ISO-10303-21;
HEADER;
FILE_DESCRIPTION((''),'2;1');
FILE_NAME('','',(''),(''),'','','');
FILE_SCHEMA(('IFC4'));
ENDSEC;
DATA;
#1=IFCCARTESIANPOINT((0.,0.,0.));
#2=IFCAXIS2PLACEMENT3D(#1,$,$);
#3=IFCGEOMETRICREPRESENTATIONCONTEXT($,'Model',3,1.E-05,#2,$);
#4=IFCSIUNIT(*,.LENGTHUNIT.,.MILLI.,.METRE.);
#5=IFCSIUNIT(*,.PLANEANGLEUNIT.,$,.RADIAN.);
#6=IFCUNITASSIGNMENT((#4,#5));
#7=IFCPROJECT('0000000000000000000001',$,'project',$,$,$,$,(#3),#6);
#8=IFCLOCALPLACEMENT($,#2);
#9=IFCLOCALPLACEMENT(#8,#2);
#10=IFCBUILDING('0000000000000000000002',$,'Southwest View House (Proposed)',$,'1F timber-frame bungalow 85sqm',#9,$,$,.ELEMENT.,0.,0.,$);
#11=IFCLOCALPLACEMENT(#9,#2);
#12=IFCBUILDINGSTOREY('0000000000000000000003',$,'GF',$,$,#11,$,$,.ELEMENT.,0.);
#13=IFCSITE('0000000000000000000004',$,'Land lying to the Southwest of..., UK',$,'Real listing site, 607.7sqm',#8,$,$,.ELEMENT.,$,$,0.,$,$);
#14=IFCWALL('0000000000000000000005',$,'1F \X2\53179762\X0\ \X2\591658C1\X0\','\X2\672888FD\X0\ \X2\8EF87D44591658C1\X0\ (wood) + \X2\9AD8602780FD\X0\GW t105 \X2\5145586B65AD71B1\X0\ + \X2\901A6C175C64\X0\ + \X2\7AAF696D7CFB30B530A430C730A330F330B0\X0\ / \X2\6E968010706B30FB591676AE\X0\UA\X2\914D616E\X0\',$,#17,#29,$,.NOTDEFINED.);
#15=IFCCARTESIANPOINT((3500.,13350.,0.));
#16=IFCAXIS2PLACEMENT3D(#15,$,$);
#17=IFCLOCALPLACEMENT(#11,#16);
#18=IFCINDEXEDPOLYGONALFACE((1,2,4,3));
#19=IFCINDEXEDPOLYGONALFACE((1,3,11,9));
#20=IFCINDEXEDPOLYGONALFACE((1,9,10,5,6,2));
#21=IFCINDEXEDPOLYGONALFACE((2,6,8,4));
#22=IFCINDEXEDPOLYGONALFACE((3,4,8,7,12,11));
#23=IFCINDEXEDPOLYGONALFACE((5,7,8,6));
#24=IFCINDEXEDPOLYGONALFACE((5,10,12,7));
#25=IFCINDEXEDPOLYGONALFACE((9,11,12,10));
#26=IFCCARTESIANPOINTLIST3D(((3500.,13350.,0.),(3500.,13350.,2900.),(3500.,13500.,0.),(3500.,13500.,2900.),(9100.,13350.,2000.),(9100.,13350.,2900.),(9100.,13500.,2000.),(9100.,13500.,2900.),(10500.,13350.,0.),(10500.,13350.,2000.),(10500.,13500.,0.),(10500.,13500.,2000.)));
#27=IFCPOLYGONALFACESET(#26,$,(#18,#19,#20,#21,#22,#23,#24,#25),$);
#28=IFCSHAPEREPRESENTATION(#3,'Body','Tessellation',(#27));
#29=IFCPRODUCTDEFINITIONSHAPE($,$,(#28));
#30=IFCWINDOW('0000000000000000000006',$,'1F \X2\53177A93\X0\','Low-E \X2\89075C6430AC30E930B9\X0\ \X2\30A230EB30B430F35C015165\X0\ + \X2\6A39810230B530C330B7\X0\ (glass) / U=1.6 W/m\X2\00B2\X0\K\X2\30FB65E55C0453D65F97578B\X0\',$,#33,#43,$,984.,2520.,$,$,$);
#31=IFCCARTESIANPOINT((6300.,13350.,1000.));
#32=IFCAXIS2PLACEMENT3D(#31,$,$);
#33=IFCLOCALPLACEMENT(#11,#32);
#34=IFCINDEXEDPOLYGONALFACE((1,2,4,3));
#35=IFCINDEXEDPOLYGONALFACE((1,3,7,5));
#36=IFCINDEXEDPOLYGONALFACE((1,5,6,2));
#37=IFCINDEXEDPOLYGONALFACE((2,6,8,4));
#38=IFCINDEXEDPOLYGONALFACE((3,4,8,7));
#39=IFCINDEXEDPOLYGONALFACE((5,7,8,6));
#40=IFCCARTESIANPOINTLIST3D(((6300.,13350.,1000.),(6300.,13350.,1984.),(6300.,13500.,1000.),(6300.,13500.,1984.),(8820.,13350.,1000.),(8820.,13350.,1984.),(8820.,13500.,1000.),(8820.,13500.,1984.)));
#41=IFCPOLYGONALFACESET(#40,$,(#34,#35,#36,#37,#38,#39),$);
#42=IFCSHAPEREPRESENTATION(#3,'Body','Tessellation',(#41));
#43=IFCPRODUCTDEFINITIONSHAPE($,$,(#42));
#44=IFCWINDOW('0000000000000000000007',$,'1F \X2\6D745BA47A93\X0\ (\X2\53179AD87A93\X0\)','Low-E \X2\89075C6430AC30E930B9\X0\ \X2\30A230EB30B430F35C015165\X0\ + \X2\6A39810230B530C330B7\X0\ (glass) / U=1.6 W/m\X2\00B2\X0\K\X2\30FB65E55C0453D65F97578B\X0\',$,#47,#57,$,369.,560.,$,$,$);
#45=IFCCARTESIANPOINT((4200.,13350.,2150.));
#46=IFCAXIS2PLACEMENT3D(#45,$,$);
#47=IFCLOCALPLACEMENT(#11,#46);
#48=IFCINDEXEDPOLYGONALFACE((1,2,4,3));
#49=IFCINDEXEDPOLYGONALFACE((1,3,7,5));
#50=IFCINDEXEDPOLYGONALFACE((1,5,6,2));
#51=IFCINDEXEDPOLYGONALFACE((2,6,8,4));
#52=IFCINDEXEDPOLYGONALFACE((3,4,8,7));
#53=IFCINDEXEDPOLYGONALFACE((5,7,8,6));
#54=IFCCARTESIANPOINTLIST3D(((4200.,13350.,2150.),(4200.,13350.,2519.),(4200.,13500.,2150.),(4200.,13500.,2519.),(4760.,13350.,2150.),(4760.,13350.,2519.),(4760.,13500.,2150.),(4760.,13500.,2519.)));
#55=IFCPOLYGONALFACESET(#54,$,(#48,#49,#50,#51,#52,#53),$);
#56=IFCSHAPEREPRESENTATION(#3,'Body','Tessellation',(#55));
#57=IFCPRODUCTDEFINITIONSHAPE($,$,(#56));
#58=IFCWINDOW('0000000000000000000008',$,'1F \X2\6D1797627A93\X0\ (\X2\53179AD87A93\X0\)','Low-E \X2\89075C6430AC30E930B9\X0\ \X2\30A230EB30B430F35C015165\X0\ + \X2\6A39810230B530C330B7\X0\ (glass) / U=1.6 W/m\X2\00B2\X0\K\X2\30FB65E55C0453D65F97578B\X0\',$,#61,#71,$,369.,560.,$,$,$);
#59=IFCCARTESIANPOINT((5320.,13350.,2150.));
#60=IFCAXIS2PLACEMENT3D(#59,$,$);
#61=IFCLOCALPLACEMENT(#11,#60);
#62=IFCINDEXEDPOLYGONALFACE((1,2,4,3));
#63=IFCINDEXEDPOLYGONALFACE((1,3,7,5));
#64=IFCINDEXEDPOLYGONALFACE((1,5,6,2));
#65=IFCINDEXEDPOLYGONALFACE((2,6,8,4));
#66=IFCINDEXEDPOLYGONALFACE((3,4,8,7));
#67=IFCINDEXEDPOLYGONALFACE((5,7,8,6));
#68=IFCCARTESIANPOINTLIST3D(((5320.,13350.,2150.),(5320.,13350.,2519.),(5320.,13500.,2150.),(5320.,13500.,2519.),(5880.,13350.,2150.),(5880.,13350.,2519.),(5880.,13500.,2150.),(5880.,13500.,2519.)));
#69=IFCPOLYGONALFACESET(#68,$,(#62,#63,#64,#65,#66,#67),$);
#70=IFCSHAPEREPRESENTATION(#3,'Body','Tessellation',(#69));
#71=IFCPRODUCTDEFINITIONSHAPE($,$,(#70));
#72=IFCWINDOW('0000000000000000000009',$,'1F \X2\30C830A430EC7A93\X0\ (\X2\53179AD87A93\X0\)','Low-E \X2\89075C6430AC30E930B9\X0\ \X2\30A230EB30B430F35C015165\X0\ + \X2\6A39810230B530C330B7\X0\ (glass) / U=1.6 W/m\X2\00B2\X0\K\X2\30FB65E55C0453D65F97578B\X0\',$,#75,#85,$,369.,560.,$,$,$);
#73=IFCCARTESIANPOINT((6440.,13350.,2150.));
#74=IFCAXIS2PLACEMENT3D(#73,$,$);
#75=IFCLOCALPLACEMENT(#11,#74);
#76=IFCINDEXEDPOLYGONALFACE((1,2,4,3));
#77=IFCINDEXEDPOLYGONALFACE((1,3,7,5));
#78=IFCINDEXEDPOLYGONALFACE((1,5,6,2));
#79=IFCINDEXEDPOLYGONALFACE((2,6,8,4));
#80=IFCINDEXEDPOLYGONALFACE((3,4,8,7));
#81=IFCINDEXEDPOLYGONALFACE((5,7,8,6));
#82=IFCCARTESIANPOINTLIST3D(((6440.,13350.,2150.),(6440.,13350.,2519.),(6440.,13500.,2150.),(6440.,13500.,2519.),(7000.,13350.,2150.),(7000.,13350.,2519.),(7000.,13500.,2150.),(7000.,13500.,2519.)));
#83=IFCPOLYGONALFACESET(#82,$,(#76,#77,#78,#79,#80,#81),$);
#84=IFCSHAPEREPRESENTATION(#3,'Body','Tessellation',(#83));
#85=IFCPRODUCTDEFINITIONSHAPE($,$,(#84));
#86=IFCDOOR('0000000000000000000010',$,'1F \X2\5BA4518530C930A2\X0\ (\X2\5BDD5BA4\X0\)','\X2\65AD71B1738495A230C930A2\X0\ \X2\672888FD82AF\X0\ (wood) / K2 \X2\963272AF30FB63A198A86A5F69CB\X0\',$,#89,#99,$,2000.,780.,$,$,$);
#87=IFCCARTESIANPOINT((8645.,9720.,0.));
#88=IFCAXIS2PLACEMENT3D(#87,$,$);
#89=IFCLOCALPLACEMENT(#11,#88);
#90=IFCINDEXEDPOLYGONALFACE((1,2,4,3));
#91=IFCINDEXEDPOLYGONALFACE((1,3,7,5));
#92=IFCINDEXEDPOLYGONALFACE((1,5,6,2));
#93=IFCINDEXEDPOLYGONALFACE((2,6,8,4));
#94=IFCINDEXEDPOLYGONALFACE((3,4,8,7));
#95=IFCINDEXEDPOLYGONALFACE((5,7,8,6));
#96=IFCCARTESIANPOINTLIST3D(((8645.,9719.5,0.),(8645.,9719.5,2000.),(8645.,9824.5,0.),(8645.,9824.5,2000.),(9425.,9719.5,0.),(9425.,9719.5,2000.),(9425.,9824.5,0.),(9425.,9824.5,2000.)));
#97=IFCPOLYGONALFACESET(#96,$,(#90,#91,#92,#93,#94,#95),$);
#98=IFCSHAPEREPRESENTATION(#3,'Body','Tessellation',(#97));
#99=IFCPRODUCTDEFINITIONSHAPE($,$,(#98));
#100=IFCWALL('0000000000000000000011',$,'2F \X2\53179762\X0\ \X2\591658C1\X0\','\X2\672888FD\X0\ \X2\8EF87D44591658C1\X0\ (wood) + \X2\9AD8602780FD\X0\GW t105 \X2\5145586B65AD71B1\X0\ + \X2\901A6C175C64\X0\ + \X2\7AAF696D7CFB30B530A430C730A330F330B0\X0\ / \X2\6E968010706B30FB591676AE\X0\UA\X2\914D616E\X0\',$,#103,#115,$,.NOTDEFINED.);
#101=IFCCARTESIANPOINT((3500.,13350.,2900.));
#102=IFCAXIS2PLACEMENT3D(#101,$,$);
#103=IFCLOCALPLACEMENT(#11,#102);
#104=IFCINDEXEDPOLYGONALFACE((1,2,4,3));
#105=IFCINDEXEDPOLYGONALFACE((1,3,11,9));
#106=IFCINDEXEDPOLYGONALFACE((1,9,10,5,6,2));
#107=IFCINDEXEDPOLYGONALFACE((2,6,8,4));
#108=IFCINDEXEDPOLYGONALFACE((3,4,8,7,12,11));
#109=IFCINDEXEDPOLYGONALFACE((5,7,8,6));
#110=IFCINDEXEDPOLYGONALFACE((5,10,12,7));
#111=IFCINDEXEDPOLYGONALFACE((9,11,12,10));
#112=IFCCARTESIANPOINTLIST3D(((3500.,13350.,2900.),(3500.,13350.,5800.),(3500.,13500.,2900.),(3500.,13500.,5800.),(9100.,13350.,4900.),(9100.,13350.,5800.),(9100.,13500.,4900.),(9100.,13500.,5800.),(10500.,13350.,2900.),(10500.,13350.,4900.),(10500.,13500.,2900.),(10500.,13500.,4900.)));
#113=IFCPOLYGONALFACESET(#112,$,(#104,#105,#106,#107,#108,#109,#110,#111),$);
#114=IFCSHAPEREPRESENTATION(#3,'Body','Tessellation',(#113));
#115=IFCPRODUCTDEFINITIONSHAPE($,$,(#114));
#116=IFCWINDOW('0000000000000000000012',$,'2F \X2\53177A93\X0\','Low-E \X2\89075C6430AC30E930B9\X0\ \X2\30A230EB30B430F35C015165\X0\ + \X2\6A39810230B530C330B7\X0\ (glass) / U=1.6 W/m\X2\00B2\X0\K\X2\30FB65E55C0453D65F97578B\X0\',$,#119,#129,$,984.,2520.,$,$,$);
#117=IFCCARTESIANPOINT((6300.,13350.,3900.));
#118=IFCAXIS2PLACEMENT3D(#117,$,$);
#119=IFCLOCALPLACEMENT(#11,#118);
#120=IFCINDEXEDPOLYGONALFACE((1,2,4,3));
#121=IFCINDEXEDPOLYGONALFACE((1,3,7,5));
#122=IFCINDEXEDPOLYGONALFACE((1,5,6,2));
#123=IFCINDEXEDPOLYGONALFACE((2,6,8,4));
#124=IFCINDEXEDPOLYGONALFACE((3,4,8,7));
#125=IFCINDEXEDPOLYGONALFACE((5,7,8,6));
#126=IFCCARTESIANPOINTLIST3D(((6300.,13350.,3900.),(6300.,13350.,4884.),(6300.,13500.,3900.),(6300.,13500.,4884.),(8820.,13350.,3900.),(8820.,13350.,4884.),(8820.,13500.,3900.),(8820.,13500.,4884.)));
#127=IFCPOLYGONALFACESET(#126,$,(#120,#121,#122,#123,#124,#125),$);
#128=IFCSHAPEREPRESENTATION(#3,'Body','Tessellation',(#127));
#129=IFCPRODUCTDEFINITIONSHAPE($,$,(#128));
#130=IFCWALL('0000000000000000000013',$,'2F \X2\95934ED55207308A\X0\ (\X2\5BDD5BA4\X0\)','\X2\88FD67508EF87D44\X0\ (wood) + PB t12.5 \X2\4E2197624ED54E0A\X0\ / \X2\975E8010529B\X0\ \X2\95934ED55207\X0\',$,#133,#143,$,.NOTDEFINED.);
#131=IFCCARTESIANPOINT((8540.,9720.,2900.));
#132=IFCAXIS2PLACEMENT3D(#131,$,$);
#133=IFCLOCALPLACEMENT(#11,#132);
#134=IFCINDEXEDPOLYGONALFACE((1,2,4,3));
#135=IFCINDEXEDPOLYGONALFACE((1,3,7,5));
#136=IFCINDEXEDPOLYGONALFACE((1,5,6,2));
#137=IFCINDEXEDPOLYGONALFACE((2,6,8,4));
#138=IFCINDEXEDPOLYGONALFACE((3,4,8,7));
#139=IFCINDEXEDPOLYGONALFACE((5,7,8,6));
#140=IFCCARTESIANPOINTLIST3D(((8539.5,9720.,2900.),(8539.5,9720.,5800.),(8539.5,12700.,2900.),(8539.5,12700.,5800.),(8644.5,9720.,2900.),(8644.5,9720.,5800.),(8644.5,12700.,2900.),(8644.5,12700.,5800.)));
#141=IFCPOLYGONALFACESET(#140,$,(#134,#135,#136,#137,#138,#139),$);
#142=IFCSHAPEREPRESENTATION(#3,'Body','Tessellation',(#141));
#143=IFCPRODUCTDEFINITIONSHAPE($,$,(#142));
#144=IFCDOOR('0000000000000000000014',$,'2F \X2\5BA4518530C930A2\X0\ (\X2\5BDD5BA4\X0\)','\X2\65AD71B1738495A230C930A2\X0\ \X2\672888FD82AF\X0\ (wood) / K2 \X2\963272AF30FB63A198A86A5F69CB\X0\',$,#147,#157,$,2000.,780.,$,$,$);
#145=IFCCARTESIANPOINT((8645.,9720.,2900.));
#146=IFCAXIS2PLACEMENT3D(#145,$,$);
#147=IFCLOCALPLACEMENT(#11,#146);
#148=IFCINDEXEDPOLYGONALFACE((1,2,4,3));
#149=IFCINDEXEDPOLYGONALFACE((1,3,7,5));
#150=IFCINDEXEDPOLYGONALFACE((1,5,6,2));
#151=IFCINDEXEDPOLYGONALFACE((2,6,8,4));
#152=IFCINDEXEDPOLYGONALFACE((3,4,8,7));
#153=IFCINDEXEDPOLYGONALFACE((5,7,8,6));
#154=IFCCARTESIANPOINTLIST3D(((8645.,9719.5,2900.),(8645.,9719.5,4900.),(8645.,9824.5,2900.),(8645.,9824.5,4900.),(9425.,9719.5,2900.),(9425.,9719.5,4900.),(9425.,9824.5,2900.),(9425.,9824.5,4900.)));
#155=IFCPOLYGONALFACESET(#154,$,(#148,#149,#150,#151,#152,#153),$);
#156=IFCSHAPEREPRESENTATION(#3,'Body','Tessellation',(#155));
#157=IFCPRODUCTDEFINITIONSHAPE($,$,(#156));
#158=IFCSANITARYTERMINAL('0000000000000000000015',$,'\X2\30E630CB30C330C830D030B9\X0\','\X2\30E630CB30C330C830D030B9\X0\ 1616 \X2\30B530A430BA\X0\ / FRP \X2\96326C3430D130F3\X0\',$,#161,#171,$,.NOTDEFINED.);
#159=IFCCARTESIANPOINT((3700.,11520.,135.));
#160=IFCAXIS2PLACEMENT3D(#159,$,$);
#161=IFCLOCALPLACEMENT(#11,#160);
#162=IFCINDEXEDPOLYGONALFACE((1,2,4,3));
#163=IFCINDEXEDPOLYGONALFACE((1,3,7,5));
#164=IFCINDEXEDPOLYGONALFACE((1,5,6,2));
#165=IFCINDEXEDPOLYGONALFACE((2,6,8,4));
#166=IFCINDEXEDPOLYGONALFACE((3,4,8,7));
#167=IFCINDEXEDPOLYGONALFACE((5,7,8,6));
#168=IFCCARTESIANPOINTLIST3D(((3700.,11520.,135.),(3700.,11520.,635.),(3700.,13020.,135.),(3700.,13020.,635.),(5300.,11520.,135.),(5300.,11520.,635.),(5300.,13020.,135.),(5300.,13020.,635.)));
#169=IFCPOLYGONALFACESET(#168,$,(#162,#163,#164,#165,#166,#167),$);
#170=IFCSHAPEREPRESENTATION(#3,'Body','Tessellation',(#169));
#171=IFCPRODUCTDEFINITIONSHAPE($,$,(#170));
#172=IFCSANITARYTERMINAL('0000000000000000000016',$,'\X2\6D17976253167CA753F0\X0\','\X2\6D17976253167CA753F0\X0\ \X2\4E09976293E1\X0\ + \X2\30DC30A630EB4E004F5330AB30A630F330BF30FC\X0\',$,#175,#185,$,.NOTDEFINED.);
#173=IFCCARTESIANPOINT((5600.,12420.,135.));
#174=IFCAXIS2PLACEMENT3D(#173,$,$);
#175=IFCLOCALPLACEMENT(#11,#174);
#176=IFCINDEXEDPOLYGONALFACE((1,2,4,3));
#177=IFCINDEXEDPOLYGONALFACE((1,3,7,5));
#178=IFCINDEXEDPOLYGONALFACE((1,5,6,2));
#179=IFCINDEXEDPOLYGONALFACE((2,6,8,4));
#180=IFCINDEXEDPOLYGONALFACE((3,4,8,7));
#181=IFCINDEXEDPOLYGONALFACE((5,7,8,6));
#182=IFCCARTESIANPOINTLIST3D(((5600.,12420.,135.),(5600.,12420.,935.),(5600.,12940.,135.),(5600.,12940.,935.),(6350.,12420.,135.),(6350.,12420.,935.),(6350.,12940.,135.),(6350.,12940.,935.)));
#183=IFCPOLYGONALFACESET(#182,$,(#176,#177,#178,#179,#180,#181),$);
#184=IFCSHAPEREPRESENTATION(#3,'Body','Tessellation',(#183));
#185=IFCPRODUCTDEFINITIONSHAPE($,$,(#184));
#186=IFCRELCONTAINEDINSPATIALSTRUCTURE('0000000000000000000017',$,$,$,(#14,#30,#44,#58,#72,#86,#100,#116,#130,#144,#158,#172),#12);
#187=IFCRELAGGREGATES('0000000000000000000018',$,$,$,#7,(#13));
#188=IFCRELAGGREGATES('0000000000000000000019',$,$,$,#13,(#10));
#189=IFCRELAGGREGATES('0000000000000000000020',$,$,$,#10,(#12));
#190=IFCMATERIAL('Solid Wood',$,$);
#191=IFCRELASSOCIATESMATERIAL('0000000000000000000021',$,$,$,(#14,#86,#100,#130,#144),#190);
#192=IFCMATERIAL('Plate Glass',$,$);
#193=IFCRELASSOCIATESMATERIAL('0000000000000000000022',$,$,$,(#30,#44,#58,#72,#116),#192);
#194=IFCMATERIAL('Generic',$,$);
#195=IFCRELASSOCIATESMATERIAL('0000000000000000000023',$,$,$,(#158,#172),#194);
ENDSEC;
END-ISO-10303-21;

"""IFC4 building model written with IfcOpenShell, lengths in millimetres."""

from ifc_helpers import new_model, si_unit, frame, frame_2d, origin, place, context, project, spatial, rectangle, extrude, material, element, fill, save


model = new_model("IFC4")

# Units and contexts
model_context = context("Model", 3, precision=1e-05, world=origin())
ifc_project = project(units=[si_unit("LENGTHUNIT", "METRE", prefix="MILLI"), si_unit("PLANEANGLEUNIT", "RADIAN")], contexts=[model_context])

# Site, building, storey
site_placement = place(None, origin())
site = spatial("IfcSite", under=ifc_project, at=site_placement, Name="Land lying to the Southwest of..., UK", ObjectType="Real listing site, 607.7sqm", CompositionType="ELEMENT", RefElevation=0.0)
building_placement = place(site_placement, origin())
building = spatial("IfcBuilding", under=site, at=building_placement, Name="Southwest View House (Proposed)", ObjectType="1F timber-frame bungalow 85sqm", CompositionType="ELEMENT", ElevationOfRefHeight=0.0, ElevationOfTerrain=0.0)
storey_placement = place(building_placement, origin())
storey = spatial("IfcBuildingStorey", under=building, at=storey_placement, Name="GF", CompositionType="ELEMENT", Elevation=0.0)

# Wall, openings, windows
ifc_material_1 = material(Name="Solid Wood")
wall_1_placement = place(storey_placement, frame((3500.0, 13350.0, 0.0)))
wall_1 = element("IfcWall", 1, at=wall_1_placement, inside=storey, material=ifc_material_1, Name="1F 北面 外壁", Description="木製 軸組外壁 (wood) + 高性能GW t105 充填断熱 + 通気層 + 窯業系サイディング / 準耐火・外皮UA配慮", PredefinedType="NOTDEFINED", context=model_context, shape_type="SweptSolid", body=[
    extrude(rectangle(XDim=7000.0, YDim=150.0, at=frame_2d((3500.0, 75.0))), frame((3500.0, 13350.0, 0.0)), (0.0, 0.0, 1.0), 2900.0),
])
opening_1_placement = place(storey_placement, frame((6300.0, 13350.0, 1000.0)))
opening_1 = element("IfcOpeningElement", 2, at=opening_1_placement, cuts=wall_1, PredefinedType="NOTDEFINED", context=model_context, shape_type="SweptSolid", body=[
    extrude(rectangle(XDim=2520.0, YDim=150.0, at=frame_2d((1260.0, 75.0))), frame((6300.0, 13350.0, 1000.0)), (0.0, 0.0, 1.0), 984.0),
])
opening_2_placement = place(storey_placement, frame((4200.0, 13350.0, 2150.0)))
opening_2 = element("IfcOpeningElement", 3, at=opening_2_placement, cuts=wall_1, PredefinedType="NOTDEFINED", context=model_context, shape_type="SweptSolid", body=[
    extrude(rectangle(XDim=560.0, YDim=150.0, at=frame_2d((280.0, 75.0))), frame((4200.0, 13350.0, 2150.0)), (0.0, 0.0, 1.0), 369.0),
])
opening_3_placement = place(storey_placement, frame((5320.0, 13350.0, 2150.0)))
opening_3 = element("IfcOpeningElement", 4, at=opening_3_placement, cuts=wall_1, PredefinedType="NOTDEFINED", context=model_context, shape_type="SweptSolid", body=[
    extrude(rectangle(XDim=560.0, YDim=150.0, at=frame_2d((280.0, 75.0))), frame((5320.0, 13350.0, 2150.0)), (0.0, 0.0, 1.0), 369.0),
])
opening_4_placement = place(storey_placement, frame((6440.0, 13350.0, 2150.0)))
opening_4 = element("IfcOpeningElement", 5, at=opening_4_placement, cuts=wall_1, PredefinedType="NOTDEFINED", context=model_context, shape_type="SweptSolid", body=[
    extrude(rectangle(XDim=560.0, YDim=150.0, at=frame_2d((280.0, 75.0))), frame((6440.0, 13350.0, 2150.0)), (0.0, 0.0, 1.0), 369.0),
])
ifc_material_2 = material(Name="Plate Glass")
window_1_placement = place(storey_placement, frame((6300.0, 13350.0, 1000.0)))
window_1 = element("IfcWindow", 6, at=window_1_placement, inside=storey, material=ifc_material_2, Name="1F 北窓", Description="Low-E 複層ガラス アルゴン封入 + 樹脂サッシ (glass) / U=1.6 W/m²K・日射取得型", OverallHeight=984.0, OverallWidth=2520.0, context=model_context, shape_type="SweptSolid", body=[
    extrude(rectangle(XDim=2520.0, YDim=150.0, at=frame_2d((1260.0, 75.0))), frame((6300.0, 13350.0, 1000.0)), (0.0, 0.0, 1.0), 984.0),
])
fill(opening_1, window_1)
window_2_placement = place(storey_placement, frame((4200.0, 13350.0, 2150.0)))
window_2 = element("IfcWindow", 7, at=window_2_placement, inside=storey, material=ifc_material_2, Name="1F 浴室窓 (北高窓)", Description="Low-E 複層ガラス アルゴン封入 + 樹脂サッシ (glass) / U=1.6 W/m²K・日射取得型", OverallHeight=369.0, OverallWidth=560.0, context=model_context, shape_type="SweptSolid", body=[
    extrude(rectangle(XDim=560.0, YDim=150.0, at=frame_2d((280.0, 75.0))), frame((4200.0, 13350.0, 2150.0)), (0.0, 0.0, 1.0), 369.0),
])
fill(opening_2, window_2)
window_3_placement = place(storey_placement, frame((5320.0, 13350.0, 2150.0)))
window_3 = element("IfcWindow", 8, at=window_3_placement, inside=storey, material=ifc_material_2, Name="1F 洗面窓 (北高窓)", Description="Low-E 複層ガラス アルゴン封入 + 樹脂サッシ (glass) / U=1.6 W/m²K・日射取得型", OverallHeight=369.0, OverallWidth=560.0, context=model_context, shape_type="SweptSolid", body=[
    extrude(rectangle(XDim=560.0, YDim=150.0, at=frame_2d((280.0, 75.0))), frame((5320.0, 13350.0, 2150.0)), (0.0, 0.0, 1.0), 369.0),
])
fill(opening_3, window_3)
window_4_placement = place(storey_placement, frame((6440.0, 13350.0, 2150.0)))
window_4 = element("IfcWindow", 9, at=window_4_placement, inside=storey, material=ifc_material_2, Name="1F トイレ窓 (北高窓)", Description="Low-E 複層ガラス アルゴン封入 + 樹脂サッシ (glass) / U=1.6 W/m²K・日射取得型", OverallHeight=369.0, OverallWidth=560.0, context=model_context, shape_type="SweptSolid", body=[
    extrude(rectangle(XDim=560.0, YDim=150.0, at=frame_2d((280.0, 75.0))), frame((6440.0, 13350.0, 2150.0)), (0.0, 0.0, 1.0), 369.0),
])
fill(opening_4, window_4)

# Door
door_1_placement = place(storey_placement, frame((8645.0, 9720.0, 0.0)))
element("IfcDoor", 10, at=door_1_placement, inside=storey, material=ifc_material_1, Name="1F 室内ドア (寝室)", Description="断熱玄関ドア 木製芯 (wood) / K2 防犯・採風機構", OverallHeight=2000.0, OverallWidth=780.0, context=model_context, shape_type="SweptSolid", body=[
    extrude(rectangle(XDim=780.0, YDim=105.0, at=frame_2d((390.0, 52.0))), frame((8645.0, 9720.0, 0.0)), (0.0, 0.0, 1.0), 2000.0),
])

# Wall, opening, window
wall_2_placement = place(storey_placement, frame((3500.0, 13350.0, 2900.0)))
wall_2 = element("IfcWall", 11, at=wall_2_placement, inside=storey, material=ifc_material_1, Name="2F 北面 外壁", Description="木製 軸組外壁 (wood) + 高性能GW t105 充填断熱 + 通気層 + 窯業系サイディング / 準耐火・外皮UA配慮", PredefinedType="NOTDEFINED", context=model_context, shape_type="SweptSolid", body=[
    extrude(rectangle(XDim=7000.0, YDim=150.0, at=frame_2d((3500.0, 75.0))), frame((3500.0, 13350.0, 2900.0)), (0.0, 0.0, 1.0), 2900.0),
])
opening_5_placement = place(storey_placement, frame((6300.0, 13350.0, 3900.0)))
opening_5 = element("IfcOpeningElement", 12, at=opening_5_placement, cuts=wall_2, PredefinedType="NOTDEFINED", context=model_context, shape_type="SweptSolid", body=[
    extrude(rectangle(XDim=2520.0, YDim=150.0, at=frame_2d((1260.0, 75.0))), frame((6300.0, 13350.0, 3900.0)), (0.0, 0.0, 1.0), 984.0),
])
window_5_placement = place(storey_placement, frame((6300.0, 13350.0, 3900.0)))
window_5 = element("IfcWindow", 13, at=window_5_placement, inside=storey, material=ifc_material_2, Name="2F 北窓", Description="Low-E 複層ガラス アルゴン封入 + 樹脂サッシ (glass) / U=1.6 W/m²K・日射取得型", OverallHeight=984.0, OverallWidth=2520.0, context=model_context, shape_type="SweptSolid", body=[
    extrude(rectangle(XDim=2520.0, YDim=150.0, at=frame_2d((1260.0, 75.0))), frame((6300.0, 13350.0, 3900.0)), (0.0, 0.0, 1.0), 984.0),
])
fill(opening_5, window_5)

# Wall
wall_3_placement = place(storey_placement, frame((8540.0, 9720.0, 2900.0)))
element("IfcWall", 14, at=wall_3_placement, inside=storey, material=ifc_material_1, Name="2F 間仕切り (寝室)", Description="製材軸組 (wood) + PB t12.5 両面仕上 / 非耐力 間仕切", PredefinedType="NOTDEFINED", context=model_context, shape_type="SweptSolid", body=[
    extrude(rectangle(XDim=105.0, YDim=2980.0, at=frame_2d((52.0, 1490.0))), frame((8540.0, 9720.0, 2900.0)), (0.0, 0.0, 1.0), 2900.0),
])

# Door
door_2_placement = place(storey_placement, frame((8645.0, 9720.0, 2900.0)))
element("IfcDoor", 15, at=door_2_placement, inside=storey, material=ifc_material_1, Name="2F 室内ドア (寝室)", Description="断熱玄関ドア 木製芯 (wood) / K2 防犯・採風機構", OverallHeight=2000.0, OverallWidth=780.0, context=model_context, shape_type="SweptSolid", body=[
    extrude(rectangle(XDim=780.0, YDim=105.0, at=frame_2d((390.0, 52.0))), frame((8645.0, 9720.0, 2900.0)), (0.0, 0.0, 1.0), 2000.0),
])

# Sanitary terminals
ifc_material_3 = material(Name="Generic")
sanitary_terminal_1_placement = place(storey_placement, frame((3700.0, 11520.0, 135.0)))
element("IfcSanitaryTerminal", 16, at=sanitary_terminal_1_placement, inside=storey, material=ifc_material_3, Name="ユニットバス", Description="ユニットバス 1616 サイズ / FRP 防水パン", PredefinedType="NOTDEFINED", context=model_context, shape_type="SweptSolid", body=[
    extrude(rectangle(XDim=1600.0, YDim=1500.0, at=frame_2d((800.0, 750.0))), frame((3700.0, 11520.0, 135.0)), (0.0, 0.0, 1.0), 500.0),
])
sanitary_terminal_2_placement = place(storey_placement, frame((5600.0, 12420.0, 135.0)))
element("IfcSanitaryTerminal", 17, at=sanitary_terminal_2_placement, inside=storey, material=ifc_material_3, Name="洗面化粧台", Description="洗面化粧台 三面鏡 + ボウル一体カウンター", PredefinedType="NOTDEFINED", context=model_context, shape_type="SweptSolid", body=[
    extrude(rectangle(XDim=750.0, YDim=520.0, at=frame_2d((375.0, 260.0))), frame((5600.0, 12420.0, 135.0)), (0.0, 0.0, 1.0), 800.0),
])

save(model, "model.ifc")
